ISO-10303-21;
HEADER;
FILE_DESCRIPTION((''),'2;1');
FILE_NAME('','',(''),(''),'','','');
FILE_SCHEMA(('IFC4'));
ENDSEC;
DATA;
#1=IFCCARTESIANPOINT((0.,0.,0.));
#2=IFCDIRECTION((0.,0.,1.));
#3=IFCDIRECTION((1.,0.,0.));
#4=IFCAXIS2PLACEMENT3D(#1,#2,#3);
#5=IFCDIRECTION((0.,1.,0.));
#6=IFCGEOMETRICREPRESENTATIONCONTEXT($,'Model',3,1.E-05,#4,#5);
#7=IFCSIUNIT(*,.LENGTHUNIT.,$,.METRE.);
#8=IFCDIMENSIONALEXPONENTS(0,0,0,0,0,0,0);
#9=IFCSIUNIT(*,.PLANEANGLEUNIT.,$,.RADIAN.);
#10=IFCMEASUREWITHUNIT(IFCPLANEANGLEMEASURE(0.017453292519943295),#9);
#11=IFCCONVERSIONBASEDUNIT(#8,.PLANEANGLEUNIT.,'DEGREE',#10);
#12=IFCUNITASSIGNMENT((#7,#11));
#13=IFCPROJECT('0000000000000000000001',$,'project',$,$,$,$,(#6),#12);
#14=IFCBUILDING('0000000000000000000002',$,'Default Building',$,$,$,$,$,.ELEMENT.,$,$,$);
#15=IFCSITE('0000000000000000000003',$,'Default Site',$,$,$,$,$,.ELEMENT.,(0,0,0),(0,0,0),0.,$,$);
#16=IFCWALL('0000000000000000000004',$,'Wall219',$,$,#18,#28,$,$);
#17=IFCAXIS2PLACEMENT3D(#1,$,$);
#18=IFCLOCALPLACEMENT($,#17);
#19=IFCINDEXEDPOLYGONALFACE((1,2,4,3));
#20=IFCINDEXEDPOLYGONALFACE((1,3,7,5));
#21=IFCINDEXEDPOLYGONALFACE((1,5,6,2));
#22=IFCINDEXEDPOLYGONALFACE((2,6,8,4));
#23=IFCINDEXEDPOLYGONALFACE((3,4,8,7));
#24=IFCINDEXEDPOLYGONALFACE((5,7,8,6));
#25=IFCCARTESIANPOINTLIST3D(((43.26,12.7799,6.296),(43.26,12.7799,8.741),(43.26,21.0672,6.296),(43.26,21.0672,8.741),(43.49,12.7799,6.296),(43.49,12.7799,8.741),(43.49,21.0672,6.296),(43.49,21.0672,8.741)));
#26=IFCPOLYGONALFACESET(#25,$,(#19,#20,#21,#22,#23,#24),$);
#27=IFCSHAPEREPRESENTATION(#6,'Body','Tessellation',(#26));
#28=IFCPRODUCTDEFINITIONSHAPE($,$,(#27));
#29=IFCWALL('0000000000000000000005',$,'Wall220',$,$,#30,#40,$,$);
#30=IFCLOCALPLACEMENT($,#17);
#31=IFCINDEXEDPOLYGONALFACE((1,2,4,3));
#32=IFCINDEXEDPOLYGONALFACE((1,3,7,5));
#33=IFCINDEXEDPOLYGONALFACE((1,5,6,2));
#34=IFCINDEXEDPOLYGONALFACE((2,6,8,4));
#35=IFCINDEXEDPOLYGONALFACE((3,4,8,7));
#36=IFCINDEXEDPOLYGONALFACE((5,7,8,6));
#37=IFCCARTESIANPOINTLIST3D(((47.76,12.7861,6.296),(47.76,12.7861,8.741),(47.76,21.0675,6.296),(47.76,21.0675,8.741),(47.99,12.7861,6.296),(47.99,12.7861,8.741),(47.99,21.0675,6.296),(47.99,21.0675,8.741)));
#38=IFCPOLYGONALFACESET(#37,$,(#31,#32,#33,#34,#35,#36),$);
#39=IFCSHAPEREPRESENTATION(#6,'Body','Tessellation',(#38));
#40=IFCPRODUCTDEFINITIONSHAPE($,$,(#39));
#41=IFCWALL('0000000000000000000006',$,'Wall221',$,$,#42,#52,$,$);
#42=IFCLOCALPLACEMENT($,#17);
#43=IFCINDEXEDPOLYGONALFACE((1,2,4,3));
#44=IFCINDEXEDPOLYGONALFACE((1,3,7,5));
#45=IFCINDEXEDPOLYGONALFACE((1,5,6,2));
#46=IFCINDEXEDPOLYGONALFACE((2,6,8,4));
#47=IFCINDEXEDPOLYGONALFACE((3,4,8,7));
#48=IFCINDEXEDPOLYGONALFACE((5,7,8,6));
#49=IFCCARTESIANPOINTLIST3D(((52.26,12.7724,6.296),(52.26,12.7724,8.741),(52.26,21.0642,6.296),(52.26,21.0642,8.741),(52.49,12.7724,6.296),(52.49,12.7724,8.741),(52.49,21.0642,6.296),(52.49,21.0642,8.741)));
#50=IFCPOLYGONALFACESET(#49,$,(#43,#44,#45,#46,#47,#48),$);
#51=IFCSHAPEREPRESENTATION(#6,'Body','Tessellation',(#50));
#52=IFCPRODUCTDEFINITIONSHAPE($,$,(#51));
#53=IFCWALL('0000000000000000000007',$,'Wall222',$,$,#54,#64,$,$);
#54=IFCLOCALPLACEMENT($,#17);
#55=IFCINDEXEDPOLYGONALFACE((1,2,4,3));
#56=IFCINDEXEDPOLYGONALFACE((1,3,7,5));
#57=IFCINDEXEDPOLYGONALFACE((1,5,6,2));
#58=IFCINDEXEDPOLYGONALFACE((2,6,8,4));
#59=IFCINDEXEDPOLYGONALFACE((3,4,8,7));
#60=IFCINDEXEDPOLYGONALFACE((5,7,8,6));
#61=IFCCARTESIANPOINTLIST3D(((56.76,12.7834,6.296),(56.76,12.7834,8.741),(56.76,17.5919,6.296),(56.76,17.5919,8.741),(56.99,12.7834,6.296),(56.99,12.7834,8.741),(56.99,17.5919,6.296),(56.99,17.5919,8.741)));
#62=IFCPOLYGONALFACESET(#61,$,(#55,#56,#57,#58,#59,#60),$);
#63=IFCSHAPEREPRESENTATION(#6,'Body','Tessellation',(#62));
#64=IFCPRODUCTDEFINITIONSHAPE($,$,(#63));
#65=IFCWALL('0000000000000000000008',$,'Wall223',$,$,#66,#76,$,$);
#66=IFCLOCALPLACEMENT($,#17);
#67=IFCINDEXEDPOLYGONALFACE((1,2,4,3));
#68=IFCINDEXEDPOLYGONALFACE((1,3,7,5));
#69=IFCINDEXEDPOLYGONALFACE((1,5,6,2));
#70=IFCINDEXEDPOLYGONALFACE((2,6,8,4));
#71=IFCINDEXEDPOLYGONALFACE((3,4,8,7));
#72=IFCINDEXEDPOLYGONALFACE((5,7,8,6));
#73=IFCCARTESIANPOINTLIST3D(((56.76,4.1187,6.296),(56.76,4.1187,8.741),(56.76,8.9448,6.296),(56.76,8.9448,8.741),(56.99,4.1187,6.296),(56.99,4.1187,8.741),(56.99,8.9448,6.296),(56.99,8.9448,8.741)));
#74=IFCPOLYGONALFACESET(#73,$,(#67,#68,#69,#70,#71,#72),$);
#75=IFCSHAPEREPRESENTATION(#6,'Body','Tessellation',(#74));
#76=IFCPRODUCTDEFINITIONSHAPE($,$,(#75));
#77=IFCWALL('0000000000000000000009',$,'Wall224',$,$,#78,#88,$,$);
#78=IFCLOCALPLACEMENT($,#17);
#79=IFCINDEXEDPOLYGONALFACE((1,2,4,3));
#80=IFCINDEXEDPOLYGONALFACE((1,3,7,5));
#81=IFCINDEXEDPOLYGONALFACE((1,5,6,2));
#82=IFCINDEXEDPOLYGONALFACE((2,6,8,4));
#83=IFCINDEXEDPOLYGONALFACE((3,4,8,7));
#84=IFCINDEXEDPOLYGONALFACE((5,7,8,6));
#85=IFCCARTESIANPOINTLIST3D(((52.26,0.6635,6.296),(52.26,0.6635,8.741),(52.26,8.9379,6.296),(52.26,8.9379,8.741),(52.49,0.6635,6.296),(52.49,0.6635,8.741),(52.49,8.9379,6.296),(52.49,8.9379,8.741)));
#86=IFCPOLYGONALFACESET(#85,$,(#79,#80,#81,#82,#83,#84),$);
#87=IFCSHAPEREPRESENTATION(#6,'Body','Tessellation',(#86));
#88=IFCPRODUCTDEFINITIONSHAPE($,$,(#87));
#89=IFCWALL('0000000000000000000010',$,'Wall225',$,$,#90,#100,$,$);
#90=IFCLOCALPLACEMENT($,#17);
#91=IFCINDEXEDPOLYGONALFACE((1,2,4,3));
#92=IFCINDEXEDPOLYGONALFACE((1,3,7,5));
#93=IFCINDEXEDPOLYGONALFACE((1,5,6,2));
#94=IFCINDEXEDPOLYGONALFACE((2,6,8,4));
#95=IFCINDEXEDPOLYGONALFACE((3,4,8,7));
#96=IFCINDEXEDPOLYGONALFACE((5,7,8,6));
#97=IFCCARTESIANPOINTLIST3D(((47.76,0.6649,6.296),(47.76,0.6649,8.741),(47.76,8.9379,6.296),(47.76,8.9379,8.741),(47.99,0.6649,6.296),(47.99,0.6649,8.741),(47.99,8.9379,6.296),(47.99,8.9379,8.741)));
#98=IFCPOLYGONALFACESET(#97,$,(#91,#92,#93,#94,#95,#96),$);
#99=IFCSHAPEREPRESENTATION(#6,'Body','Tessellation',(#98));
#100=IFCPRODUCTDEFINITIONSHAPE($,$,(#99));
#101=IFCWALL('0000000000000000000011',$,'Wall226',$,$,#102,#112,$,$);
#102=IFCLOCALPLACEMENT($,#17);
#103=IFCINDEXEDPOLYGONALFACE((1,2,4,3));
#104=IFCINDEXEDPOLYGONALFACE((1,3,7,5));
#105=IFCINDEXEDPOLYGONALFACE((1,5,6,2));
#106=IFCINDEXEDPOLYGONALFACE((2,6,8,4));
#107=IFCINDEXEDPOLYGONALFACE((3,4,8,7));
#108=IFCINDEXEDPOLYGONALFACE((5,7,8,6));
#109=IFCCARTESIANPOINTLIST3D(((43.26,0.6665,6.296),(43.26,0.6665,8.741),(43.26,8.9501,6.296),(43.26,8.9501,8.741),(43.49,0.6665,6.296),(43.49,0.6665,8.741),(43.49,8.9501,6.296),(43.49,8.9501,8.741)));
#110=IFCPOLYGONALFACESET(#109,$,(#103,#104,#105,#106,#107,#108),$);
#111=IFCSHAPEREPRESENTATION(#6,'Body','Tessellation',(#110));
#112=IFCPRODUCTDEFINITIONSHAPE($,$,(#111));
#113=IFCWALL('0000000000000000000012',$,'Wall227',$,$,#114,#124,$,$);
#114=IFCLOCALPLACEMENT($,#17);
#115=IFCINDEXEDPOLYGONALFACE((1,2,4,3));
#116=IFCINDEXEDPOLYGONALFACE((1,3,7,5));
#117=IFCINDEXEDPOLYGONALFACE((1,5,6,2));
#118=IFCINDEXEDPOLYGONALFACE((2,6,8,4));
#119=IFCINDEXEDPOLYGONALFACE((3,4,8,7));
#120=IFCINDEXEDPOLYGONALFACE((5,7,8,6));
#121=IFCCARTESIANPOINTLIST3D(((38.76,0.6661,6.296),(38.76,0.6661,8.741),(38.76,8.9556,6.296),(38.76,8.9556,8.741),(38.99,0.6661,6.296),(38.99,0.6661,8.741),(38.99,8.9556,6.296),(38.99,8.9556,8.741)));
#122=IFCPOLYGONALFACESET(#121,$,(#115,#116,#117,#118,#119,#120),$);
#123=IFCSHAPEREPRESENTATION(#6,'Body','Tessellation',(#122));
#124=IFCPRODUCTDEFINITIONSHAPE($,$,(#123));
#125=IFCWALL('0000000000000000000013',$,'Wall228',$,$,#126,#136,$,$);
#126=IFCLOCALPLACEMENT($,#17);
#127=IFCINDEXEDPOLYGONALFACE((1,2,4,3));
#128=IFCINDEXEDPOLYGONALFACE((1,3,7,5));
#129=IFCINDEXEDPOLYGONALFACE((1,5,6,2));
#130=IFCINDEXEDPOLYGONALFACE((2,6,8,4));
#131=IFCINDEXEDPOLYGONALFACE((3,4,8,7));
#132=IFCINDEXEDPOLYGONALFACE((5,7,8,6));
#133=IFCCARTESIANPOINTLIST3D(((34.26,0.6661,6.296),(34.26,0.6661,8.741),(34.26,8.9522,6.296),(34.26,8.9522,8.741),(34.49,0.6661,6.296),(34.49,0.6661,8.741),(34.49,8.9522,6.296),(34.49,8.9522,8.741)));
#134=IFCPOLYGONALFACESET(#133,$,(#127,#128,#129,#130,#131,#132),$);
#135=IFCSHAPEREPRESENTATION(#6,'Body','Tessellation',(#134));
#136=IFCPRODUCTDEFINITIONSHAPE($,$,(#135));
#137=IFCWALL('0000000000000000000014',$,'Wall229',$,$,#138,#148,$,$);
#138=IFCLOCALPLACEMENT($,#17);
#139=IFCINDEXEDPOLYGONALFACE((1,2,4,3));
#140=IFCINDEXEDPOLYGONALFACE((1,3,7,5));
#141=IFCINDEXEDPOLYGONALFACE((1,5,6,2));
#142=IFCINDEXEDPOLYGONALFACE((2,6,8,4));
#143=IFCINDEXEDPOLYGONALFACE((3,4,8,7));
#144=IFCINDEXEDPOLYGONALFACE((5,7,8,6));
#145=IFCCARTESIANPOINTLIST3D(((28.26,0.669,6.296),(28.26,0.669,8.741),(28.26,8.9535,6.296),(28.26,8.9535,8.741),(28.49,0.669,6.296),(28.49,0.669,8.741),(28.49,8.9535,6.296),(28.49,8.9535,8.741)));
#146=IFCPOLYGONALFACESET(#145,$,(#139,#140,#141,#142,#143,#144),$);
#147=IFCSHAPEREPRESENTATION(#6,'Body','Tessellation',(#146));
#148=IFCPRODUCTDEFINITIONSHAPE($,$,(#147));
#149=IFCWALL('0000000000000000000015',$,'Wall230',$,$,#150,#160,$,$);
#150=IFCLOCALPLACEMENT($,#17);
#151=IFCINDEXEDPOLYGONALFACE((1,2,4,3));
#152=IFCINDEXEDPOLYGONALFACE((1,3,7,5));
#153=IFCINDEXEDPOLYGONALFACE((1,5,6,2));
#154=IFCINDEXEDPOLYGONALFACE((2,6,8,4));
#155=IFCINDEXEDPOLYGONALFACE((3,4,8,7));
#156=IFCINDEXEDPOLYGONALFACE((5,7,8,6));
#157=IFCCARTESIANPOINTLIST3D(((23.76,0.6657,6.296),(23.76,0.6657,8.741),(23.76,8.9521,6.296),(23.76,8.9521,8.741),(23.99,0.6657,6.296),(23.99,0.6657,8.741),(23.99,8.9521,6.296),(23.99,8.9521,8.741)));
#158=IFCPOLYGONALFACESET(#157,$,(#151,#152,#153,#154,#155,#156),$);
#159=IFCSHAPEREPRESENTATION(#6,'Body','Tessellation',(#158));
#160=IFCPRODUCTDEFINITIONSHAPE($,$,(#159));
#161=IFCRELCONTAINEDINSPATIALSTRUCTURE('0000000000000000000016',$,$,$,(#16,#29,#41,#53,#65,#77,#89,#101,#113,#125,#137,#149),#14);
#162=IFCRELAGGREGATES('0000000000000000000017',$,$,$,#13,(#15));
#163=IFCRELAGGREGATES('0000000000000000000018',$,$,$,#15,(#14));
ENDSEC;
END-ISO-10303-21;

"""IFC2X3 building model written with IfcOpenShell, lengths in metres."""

from ifc_helpers import new_model, entity, si_unit, converted_unit, direction, frame, frame_2d, origin_with_axes, place, context, project, spatial, rectangle, extrude, element, save


model = new_model("IFC2X3")

# Units and contexts
model_context = context("Model", 3, precision=1e-05, world=origin_with_axes(), true_north=direction((0.0, 1.0, 0.0)))
ifc_project = project(units=[si_unit("LENGTHUNIT", "METRE"), converted_unit("PLANEANGLEUNIT", "DEGREE", entity("IfcPlaneAngleMeasure", 0.017453292519943295), si_unit("PLANEANGLEUNIT", "RADIAN"), dimensions=[0, 0, 0, 0, 0, 0, 0])], contexts=[model_context])

# Site, building
site = spatial("IfcSite", under=ifc_project, Name="Default Site", CompositionType="ELEMENT", RefLatitude=(0, 0, 0), RefLongitude=(0, 0, 0), RefElevation=0.0)
building = spatial("IfcBuilding", under=site, Name="Default Building", CompositionType="ELEMENT")

# Shared definitions
placement = place(None, origin_with_axes())

# Walls
element("IfcWall", 1, at=placement, inside=building, Name="Wall219", context=model_context, shape_type="SweptSolid", body=[
    extrude(rectangle(XDim=8.2873, YDim=0.23, at=frame_2d((0.0, 0.0), x_axis=(0.0, 1.0, 0.0))), frame((43.375, 16.9235, 6.296), z_axis=(0.0, 0.0, 1.0), x_axis=(1.0, 0.0, 0.0)), (0.0, 0.0, 1.0), 2.445),
])
element("IfcWall", 2, at=placement, inside=building, Name="Wall220", context=model_context, shape_type="SweptSolid", body=[
    extrude(rectangle(XDim=8.2814, YDim=0.23, at=frame_2d((0.0, 0.0), x_axis=(0.0, -1.0, 0.0))), frame((47.875, 16.9268, 6.296), z_axis=(0.0, 0.0, 1.0), x_axis=(1.0, 0.0, 0.0)), (0.0, 0.0, 1.0), 2.445),
])
element("IfcWall", 3, at=placement, inside=building, Name="Wall221", context=model_context, shape_type="SweptSolid", body=[
    extrude(rectangle(XDim=8.2918, YDim=0.23, at=frame_2d((0.0, 0.0), x_axis=(0.0, -1.0, 0.0))), frame((52.375, 16.9183, 6.296), z_axis=(0.0, 0.0, 1.0), x_axis=(1.0, 0.0, 0.0)), (0.0, 0.0, 1.0), 2.445),
])
element("IfcWall", 4, at=placement, inside=building, Name="Wall222", context=model_context, shape_type="SweptSolid", body=[
    extrude(rectangle(XDim=4.8085, YDim=0.23, at=frame_2d((0.0, 0.0), x_axis=(0.0, 1.0, 0.0))), frame((56.875, 15.1877, 6.296), z_axis=(0.0, 0.0, 1.0), x_axis=(1.0, 0.0, 0.0)), (0.0, 0.0, 1.0), 2.445),
])
element("IfcWall", 5, at=placement, inside=building, Name="Wall223", context=model_context, shape_type="SweptSolid", body=[
    extrude(rectangle(XDim=4.8261, YDim=0.23, at=frame_2d((0.0, 0.0), x_axis=(0.0, -1.0, 0.0))), frame((56.875, 6.5318, 6.296), z_axis=(0.0, 0.0, 1.0), x_axis=(1.0, 0.0, 0.0)), (0.0, 0.0, 1.0), 2.445),
])
element("IfcWall", 6, at=placement, inside=building, Name="Wall224", context=model_context, shape_type="SweptSolid", body=[
    extrude(rectangle(XDim=8.2744, YDim=0.23, at=frame_2d((0.0, 0.0), x_axis=(0.0, 1.0, 0.0))), frame((52.375, 4.8007, 6.296), z_axis=(0.0, 0.0, 1.0), x_axis=(1.0, 0.0, 0.0)), (0.0, 0.0, 1.0), 2.445),
])
element("IfcWall", 7, at=placement, inside=building, Name="Wall225", context=model_context, shape_type="SweptSolid", body=[
    extrude(rectangle(XDim=8.273, YDim=0.23, at=frame_2d((0.0, 0.0), x_axis=(0.0, -1.0, 0.0))), frame((47.875, 4.8014, 6.296), z_axis=(0.0, 0.0, 1.0), x_axis=(1.0, 0.0, 0.0)), (0.0, 0.0, 1.0), 2.445),
])
element("IfcWall", 8, at=placement, inside=building, Name="Wall226", context=model_context, shape_type="SweptSolid", body=[
    extrude(rectangle(XDim=8.2836, YDim=0.23, at=frame_2d((0.0, 0.0), x_axis=(0.0, 1.0, 0.0))), frame((43.375, 4.8083, 6.296), z_axis=(0.0, 0.0, 1.0), x_axis=(1.0, 0.0, 0.0)), (0.0, 0.0, 1.0), 2.445),
])
element("IfcWall", 9, at=placement, inside=building, Name="Wall227", context=model_context, shape_type="SweptSolid", body=[
    extrude(rectangle(XDim=8.2895, YDim=0.23, at=frame_2d((0.0, 0.0), x_axis=(0.0, -1.0, 0.0))), frame((38.875, 4.8109, 6.296), z_axis=(0.0, 0.0, 1.0), x_axis=(1.0, 0.0, 0.0)), (0.0, 0.0, 1.0), 2.445),
])
element("IfcWall", 10, at=placement, inside=building, Name="Wall228", context=model_context, shape_type="SweptSolid", body=[
    extrude(rectangle(XDim=8.2861, YDim=0.23, at=frame_2d((0.0, 0.0), x_axis=(0.0, -1.0, 0.0))), frame((34.375, 4.8092, 6.296), z_axis=(0.0, 0.0, 1.0), x_axis=(1.0, 0.0, 0.0)), (0.0, 0.0, 1.0), 2.445),
])
element("IfcWall", 11, at=placement, inside=building, Name="Wall229", context=model_context, shape_type="SweptSolid", body=[
    extrude(rectangle(XDim=8.2845, YDim=0.23, at=frame_2d((0.0, 0.0), x_axis=(0.0, 1.0, 0.0))), frame((28.375, 4.8113, 6.296), z_axis=(0.0, 0.0, 1.0), x_axis=(1.0, 0.0, 0.0)), (0.0, 0.0, 1.0), 2.445),
])
element("IfcWall", 12, at=placement, inside=building, Name="Wall230", context=model_context, shape_type="SweptSolid", body=[
    extrude(rectangle(XDim=8.2865, YDim=0.23, at=frame_2d((0.0, 0.0), x_axis=(0.0, -1.0, 0.0))), frame((23.875, 4.8089, 6.296), z_axis=(0.0, 0.0, 1.0), x_axis=(1.0, 0.0, 0.0)), (0.0, 0.0, 1.0), 2.445),
])

save(model, "model.ifc")
